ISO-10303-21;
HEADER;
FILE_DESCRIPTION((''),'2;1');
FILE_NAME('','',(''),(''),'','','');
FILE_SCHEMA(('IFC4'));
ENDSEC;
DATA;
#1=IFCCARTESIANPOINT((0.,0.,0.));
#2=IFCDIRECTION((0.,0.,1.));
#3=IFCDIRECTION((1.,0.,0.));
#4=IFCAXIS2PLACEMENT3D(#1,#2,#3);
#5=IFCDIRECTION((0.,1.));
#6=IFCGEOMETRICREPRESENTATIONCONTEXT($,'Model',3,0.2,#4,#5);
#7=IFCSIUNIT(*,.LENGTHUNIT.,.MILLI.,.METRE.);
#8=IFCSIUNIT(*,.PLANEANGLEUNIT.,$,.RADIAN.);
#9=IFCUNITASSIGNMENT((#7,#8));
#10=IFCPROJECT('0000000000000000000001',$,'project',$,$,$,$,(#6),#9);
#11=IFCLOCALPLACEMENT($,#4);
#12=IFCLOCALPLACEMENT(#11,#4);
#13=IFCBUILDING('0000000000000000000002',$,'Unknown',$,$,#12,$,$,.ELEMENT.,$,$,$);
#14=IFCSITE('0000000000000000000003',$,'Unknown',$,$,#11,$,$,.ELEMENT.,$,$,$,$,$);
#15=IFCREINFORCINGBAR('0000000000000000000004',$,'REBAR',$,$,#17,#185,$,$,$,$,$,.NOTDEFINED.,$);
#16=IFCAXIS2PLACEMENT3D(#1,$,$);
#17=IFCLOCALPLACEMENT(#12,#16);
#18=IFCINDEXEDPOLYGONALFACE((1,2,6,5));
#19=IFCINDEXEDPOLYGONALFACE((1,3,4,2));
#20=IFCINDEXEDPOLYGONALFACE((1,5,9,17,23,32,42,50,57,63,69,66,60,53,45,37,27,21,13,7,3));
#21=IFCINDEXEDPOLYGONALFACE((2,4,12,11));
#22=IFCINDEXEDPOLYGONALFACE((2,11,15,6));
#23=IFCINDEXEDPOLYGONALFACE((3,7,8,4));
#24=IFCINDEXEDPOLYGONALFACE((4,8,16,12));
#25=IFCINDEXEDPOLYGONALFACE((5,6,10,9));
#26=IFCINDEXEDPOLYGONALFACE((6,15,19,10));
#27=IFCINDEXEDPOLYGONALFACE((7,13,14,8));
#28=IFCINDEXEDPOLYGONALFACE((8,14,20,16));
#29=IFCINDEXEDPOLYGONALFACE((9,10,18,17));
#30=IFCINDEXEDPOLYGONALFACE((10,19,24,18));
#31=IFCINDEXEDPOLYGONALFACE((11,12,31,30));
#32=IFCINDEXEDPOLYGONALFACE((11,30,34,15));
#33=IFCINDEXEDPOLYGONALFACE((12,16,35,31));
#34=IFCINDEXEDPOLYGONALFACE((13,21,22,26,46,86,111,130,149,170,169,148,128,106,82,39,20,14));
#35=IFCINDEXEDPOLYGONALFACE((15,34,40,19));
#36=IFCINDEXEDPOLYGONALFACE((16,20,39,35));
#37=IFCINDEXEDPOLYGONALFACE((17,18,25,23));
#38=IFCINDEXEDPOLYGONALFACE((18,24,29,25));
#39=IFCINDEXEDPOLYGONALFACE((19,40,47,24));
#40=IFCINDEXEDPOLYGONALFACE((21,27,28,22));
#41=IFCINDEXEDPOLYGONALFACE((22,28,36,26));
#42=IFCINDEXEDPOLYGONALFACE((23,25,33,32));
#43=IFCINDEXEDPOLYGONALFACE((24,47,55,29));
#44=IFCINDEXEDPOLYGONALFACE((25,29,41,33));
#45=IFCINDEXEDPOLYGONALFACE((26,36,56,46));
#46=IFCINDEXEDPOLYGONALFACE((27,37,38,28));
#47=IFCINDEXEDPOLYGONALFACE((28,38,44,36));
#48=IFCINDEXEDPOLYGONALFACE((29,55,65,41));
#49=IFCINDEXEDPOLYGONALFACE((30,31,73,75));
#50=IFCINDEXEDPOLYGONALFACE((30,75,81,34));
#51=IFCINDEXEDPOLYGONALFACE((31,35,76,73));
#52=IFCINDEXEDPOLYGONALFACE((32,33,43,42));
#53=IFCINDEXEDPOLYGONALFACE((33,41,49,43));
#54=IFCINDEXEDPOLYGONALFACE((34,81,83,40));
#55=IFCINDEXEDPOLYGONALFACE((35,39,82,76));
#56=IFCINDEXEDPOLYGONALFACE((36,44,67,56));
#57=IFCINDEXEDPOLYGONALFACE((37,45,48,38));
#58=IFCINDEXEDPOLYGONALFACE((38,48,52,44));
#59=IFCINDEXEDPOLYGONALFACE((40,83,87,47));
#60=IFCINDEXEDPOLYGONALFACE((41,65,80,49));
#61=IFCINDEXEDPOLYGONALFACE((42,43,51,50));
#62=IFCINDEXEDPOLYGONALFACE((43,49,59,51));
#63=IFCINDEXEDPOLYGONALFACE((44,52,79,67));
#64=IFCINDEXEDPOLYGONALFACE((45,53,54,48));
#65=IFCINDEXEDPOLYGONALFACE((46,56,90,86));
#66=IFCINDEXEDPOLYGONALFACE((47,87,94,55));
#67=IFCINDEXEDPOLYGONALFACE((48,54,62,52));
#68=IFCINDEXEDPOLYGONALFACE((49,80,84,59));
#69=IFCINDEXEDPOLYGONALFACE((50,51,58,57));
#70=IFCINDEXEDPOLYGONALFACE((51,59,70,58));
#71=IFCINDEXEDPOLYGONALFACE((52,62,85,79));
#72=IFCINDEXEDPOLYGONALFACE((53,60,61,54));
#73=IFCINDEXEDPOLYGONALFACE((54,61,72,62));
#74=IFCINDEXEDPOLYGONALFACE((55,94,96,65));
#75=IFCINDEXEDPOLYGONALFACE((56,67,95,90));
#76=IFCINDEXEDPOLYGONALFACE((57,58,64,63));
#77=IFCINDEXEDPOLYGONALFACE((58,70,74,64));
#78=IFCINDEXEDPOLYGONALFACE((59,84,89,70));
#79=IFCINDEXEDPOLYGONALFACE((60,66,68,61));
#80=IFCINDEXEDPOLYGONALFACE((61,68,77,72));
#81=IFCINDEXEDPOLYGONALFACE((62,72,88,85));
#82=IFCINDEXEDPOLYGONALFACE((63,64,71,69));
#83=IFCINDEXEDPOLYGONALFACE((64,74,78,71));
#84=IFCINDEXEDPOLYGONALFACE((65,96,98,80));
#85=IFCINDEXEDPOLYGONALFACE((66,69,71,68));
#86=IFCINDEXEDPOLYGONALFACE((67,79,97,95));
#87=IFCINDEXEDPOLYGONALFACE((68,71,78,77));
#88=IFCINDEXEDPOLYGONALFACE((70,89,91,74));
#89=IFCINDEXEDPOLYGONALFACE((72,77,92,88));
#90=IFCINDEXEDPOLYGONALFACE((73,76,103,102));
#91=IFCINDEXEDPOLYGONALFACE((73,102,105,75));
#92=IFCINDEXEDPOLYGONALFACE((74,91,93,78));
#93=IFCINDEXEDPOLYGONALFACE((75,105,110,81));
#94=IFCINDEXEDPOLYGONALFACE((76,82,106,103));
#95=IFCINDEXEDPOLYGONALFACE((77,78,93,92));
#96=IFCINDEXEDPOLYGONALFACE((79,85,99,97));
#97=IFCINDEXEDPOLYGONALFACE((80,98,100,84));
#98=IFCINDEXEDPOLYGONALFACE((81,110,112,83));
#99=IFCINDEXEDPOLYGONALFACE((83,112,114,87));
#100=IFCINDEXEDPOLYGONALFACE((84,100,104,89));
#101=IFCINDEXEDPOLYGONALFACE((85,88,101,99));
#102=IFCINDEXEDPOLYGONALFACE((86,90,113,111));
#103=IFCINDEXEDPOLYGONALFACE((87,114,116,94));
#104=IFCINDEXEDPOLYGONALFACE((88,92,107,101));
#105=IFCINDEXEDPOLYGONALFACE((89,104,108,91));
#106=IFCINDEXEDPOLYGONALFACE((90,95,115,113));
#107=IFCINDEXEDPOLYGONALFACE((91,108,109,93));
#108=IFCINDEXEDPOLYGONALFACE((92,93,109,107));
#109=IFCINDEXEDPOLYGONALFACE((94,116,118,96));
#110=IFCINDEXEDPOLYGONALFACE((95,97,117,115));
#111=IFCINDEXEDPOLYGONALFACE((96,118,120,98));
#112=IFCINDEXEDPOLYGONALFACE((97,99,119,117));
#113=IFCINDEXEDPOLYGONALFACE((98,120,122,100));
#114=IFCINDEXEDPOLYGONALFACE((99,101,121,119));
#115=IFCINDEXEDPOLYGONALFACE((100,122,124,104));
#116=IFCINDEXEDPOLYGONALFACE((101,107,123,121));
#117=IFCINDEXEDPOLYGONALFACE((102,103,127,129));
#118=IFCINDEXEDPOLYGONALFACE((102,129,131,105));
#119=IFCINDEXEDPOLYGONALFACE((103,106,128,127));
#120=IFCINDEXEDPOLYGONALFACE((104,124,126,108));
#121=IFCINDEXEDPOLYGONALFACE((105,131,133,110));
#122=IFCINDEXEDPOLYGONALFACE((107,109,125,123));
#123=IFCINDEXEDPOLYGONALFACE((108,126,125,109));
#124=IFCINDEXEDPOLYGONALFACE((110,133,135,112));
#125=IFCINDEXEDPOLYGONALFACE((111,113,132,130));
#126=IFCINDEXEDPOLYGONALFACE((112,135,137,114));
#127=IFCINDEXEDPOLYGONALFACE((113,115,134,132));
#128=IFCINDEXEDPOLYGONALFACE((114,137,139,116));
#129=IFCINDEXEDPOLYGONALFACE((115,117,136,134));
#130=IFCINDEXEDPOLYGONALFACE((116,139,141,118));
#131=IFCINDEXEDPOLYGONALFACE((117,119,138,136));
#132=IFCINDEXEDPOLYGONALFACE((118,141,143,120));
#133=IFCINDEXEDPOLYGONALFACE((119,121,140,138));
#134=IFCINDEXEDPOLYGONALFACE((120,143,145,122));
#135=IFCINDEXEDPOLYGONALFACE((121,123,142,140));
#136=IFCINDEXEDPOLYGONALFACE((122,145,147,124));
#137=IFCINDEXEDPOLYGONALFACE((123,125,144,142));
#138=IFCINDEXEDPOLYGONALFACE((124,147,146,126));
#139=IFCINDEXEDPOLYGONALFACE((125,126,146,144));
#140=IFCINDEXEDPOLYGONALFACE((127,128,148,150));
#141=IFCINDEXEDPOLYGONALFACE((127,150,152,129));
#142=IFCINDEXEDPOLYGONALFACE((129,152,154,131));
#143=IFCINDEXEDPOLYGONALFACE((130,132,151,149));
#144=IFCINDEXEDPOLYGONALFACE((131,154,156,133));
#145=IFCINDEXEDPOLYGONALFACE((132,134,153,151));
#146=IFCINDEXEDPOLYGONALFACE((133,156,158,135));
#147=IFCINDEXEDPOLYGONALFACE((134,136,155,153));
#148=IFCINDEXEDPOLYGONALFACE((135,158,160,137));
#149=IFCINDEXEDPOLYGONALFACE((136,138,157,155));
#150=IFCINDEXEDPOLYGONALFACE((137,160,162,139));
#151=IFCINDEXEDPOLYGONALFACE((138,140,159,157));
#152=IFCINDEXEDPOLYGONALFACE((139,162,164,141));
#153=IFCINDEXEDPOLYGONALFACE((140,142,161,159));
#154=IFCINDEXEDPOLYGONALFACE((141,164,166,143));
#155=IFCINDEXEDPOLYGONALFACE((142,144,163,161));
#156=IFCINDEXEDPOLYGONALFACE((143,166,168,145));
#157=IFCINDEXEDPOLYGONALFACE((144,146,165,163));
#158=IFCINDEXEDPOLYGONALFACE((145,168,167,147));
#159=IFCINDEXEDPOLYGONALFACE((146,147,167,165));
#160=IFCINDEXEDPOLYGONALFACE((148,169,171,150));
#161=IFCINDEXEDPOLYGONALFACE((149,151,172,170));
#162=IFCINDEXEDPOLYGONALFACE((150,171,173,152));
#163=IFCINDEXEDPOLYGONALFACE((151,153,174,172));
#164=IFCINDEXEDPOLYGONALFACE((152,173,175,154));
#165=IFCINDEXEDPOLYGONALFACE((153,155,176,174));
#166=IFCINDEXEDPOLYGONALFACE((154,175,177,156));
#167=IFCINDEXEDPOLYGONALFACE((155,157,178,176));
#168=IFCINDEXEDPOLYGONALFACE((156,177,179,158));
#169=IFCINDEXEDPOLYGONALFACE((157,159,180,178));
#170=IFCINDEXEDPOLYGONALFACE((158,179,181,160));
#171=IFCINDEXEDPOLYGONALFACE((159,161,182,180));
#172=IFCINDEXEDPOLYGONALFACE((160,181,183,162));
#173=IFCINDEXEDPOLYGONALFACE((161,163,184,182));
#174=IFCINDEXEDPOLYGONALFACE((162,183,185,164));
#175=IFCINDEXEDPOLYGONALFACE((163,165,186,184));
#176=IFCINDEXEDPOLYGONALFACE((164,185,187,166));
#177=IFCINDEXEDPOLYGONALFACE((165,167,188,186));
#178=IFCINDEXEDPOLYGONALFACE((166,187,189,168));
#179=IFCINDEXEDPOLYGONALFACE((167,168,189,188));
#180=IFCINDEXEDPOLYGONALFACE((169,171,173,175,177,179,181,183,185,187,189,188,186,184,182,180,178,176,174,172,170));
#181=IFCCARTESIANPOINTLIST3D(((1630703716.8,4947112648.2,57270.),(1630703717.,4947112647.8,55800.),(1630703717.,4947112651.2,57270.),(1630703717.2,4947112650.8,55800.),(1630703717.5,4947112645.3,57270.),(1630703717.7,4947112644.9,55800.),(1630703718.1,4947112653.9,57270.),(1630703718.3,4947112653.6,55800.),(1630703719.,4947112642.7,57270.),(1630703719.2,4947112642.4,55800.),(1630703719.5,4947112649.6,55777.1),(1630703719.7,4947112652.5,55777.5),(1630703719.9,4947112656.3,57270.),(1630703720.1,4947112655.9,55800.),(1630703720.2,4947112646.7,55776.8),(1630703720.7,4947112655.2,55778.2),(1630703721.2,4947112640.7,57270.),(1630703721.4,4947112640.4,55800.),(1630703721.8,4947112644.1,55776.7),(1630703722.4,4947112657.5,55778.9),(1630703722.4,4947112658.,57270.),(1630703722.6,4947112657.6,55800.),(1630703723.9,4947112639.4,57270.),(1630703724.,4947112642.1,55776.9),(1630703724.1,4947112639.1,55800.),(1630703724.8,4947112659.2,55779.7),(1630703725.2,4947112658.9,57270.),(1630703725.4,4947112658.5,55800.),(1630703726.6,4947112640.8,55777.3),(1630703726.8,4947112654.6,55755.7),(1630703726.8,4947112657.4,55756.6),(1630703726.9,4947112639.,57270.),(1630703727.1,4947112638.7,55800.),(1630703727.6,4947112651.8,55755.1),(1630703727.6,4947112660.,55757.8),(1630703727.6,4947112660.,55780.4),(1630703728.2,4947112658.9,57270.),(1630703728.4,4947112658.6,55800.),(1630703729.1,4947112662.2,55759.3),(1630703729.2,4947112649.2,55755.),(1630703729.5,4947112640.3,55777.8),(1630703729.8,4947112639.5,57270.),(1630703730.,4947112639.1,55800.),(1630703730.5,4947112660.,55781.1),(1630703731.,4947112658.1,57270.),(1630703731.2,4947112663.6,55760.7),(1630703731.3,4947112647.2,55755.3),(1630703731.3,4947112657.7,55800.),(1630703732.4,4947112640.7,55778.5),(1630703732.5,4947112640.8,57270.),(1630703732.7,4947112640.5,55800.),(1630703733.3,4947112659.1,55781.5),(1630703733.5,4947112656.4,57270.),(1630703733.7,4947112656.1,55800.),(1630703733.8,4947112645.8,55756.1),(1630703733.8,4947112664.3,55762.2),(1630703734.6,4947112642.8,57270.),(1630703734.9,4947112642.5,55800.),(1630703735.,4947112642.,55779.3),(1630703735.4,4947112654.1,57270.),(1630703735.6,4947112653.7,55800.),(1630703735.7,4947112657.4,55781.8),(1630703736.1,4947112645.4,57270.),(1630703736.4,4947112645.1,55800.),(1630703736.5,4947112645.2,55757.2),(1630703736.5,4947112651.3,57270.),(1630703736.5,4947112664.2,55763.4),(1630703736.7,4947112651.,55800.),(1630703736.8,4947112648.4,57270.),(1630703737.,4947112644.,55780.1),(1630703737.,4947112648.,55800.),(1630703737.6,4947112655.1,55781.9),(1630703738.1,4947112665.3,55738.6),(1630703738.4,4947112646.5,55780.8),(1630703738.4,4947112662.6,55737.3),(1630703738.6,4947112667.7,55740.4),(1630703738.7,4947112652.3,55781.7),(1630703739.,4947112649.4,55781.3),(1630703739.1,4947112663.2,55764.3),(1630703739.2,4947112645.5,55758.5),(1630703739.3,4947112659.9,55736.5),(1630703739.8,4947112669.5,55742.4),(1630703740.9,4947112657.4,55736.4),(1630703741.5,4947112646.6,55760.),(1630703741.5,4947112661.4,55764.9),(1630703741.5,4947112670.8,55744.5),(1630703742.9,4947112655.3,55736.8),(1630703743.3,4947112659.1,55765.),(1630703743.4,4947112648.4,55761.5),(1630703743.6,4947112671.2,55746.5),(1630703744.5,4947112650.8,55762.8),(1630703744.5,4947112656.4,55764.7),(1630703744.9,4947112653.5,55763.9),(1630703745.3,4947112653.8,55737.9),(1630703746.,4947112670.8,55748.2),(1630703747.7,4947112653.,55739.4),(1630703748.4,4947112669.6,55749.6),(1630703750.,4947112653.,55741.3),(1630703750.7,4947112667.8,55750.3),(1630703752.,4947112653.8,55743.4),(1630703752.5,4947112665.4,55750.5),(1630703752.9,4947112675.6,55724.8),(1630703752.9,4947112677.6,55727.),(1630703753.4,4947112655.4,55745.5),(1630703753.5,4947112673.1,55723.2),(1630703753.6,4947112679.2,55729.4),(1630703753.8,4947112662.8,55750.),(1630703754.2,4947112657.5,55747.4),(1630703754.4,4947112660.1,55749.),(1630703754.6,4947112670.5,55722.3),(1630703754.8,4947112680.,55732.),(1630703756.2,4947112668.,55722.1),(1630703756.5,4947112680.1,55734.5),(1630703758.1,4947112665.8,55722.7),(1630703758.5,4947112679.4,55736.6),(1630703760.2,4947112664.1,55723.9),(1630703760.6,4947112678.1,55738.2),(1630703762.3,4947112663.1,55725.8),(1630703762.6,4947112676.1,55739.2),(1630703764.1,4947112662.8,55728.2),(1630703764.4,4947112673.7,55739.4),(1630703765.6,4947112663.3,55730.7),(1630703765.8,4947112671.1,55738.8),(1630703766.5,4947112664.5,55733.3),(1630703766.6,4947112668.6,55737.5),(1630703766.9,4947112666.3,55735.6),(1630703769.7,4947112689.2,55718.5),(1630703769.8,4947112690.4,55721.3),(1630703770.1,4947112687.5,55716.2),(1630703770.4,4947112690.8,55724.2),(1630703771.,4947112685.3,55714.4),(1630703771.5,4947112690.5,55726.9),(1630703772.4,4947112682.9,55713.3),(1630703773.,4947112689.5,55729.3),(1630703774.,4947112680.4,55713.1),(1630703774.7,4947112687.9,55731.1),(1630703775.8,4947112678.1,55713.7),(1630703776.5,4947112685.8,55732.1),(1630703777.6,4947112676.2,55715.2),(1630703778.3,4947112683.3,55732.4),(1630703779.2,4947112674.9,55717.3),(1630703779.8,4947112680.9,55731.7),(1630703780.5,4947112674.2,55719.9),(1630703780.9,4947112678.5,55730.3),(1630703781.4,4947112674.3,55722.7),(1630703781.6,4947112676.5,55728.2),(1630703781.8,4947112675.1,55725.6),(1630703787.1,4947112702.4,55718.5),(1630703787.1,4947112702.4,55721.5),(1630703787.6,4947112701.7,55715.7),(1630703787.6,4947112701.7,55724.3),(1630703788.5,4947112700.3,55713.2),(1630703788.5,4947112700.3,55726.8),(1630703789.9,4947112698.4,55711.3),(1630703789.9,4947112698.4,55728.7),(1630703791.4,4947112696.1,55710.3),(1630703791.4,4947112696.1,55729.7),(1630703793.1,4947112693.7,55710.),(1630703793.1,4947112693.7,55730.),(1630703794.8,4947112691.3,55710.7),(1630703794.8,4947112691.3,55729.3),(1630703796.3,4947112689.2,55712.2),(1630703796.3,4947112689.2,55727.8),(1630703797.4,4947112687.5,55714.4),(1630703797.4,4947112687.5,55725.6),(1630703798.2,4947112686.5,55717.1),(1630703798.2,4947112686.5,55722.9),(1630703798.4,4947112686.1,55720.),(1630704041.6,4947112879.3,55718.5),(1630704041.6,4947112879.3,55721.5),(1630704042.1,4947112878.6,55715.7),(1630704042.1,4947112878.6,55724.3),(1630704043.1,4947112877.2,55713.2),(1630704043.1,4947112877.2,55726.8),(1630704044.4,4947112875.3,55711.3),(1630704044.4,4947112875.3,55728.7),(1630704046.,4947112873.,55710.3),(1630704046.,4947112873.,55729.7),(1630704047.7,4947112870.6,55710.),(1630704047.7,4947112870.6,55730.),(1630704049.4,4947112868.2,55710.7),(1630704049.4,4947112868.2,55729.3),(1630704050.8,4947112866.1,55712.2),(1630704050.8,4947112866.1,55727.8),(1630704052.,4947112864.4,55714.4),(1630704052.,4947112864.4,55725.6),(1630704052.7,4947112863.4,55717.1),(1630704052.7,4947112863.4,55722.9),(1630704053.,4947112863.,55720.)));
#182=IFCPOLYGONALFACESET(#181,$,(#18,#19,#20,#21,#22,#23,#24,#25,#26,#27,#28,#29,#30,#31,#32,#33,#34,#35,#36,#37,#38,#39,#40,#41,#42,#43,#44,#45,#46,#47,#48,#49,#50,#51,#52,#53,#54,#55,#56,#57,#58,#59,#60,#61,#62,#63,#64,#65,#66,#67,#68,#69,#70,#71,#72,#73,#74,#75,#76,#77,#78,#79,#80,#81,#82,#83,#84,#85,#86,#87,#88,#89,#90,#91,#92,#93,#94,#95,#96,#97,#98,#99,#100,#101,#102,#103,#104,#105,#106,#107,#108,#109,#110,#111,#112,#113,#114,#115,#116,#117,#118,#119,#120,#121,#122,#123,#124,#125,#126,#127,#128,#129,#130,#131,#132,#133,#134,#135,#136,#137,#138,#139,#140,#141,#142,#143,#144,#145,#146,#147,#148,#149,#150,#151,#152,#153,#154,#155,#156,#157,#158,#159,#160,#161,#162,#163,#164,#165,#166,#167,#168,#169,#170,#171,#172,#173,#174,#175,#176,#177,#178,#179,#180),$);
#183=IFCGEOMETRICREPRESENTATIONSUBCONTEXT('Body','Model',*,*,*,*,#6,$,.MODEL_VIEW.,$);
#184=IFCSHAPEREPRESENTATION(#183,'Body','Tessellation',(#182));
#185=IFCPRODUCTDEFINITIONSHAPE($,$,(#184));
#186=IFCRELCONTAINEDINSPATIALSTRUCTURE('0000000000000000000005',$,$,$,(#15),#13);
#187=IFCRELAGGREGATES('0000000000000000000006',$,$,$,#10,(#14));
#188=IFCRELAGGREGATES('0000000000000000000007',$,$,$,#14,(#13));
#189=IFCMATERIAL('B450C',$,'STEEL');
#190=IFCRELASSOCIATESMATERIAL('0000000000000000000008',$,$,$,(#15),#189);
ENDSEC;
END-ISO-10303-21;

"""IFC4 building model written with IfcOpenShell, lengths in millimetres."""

from ifc_helpers import new_model, entity, si_unit, direction, frame, origin_with_axes, place, context, subcontext, project, spatial, material, element, save


model = new_model("IFC4")

# Units and contexts
model_context = context("Model", 3, precision=0.2, world=origin_with_axes(), true_north=direction((0.0, 1.0)))
body_context = subcontext(model_context, "Body", "Model", "MODEL_VIEW")
ifc_project = project(units=[si_unit("LENGTHUNIT", "METRE", prefix="MILLI"), si_unit("PLANEANGLEUNIT", "RADIAN")], contexts=[model_context])

# Site, building
site_placement = place(None, origin_with_axes())
site = spatial("IfcSite", under=ifc_project, at=site_placement, Name="Unknown", CompositionType="ELEMENT")
building_placement = place(site_placement, origin_with_axes())
building = spatial("IfcBuilding", under=site, at=building_placement, Name="Unknown", CompositionType="ELEMENT")

# Reinforcing bar
ifc_material = material(Name="B450C", Category="STEEL")
reinforcing_bar_1_placement = place(building_placement, frame((1630703657.4, 4947112661.2, 55670.0), z_axis=(0.570957, -0.82098, 0.0), x_axis=(0.0, 0.0, 1.0)))
element("IfcReinforcingBar", 1, at=reinforcing_bar_1_placement, inside=building, material=ifc_material, Name="REBAR", PredefinedType="NOTDEFINED", context=body_context, shape_type="AdvancedSweptSolid", body=[
    entity("IfcSweptDiskSolid", entity("IfcIndexedPolyCurve", entity("IfcCartesianPointList3D", [[50.0, -440.0, 50.1], [50.0, -130.0, 50.0], [73.4, -73.4, 50.0], [130.0, -50.0, 50.0], [1600.0, -50.0, 49.6]]), [entity("IfcLineIndex", [1, 2]), entity("IfcArcIndex", [2, 3, 4]), entity("IfcLineIndex", [4, 5])]), 10.0),
])

save(model, "model.ifc")
